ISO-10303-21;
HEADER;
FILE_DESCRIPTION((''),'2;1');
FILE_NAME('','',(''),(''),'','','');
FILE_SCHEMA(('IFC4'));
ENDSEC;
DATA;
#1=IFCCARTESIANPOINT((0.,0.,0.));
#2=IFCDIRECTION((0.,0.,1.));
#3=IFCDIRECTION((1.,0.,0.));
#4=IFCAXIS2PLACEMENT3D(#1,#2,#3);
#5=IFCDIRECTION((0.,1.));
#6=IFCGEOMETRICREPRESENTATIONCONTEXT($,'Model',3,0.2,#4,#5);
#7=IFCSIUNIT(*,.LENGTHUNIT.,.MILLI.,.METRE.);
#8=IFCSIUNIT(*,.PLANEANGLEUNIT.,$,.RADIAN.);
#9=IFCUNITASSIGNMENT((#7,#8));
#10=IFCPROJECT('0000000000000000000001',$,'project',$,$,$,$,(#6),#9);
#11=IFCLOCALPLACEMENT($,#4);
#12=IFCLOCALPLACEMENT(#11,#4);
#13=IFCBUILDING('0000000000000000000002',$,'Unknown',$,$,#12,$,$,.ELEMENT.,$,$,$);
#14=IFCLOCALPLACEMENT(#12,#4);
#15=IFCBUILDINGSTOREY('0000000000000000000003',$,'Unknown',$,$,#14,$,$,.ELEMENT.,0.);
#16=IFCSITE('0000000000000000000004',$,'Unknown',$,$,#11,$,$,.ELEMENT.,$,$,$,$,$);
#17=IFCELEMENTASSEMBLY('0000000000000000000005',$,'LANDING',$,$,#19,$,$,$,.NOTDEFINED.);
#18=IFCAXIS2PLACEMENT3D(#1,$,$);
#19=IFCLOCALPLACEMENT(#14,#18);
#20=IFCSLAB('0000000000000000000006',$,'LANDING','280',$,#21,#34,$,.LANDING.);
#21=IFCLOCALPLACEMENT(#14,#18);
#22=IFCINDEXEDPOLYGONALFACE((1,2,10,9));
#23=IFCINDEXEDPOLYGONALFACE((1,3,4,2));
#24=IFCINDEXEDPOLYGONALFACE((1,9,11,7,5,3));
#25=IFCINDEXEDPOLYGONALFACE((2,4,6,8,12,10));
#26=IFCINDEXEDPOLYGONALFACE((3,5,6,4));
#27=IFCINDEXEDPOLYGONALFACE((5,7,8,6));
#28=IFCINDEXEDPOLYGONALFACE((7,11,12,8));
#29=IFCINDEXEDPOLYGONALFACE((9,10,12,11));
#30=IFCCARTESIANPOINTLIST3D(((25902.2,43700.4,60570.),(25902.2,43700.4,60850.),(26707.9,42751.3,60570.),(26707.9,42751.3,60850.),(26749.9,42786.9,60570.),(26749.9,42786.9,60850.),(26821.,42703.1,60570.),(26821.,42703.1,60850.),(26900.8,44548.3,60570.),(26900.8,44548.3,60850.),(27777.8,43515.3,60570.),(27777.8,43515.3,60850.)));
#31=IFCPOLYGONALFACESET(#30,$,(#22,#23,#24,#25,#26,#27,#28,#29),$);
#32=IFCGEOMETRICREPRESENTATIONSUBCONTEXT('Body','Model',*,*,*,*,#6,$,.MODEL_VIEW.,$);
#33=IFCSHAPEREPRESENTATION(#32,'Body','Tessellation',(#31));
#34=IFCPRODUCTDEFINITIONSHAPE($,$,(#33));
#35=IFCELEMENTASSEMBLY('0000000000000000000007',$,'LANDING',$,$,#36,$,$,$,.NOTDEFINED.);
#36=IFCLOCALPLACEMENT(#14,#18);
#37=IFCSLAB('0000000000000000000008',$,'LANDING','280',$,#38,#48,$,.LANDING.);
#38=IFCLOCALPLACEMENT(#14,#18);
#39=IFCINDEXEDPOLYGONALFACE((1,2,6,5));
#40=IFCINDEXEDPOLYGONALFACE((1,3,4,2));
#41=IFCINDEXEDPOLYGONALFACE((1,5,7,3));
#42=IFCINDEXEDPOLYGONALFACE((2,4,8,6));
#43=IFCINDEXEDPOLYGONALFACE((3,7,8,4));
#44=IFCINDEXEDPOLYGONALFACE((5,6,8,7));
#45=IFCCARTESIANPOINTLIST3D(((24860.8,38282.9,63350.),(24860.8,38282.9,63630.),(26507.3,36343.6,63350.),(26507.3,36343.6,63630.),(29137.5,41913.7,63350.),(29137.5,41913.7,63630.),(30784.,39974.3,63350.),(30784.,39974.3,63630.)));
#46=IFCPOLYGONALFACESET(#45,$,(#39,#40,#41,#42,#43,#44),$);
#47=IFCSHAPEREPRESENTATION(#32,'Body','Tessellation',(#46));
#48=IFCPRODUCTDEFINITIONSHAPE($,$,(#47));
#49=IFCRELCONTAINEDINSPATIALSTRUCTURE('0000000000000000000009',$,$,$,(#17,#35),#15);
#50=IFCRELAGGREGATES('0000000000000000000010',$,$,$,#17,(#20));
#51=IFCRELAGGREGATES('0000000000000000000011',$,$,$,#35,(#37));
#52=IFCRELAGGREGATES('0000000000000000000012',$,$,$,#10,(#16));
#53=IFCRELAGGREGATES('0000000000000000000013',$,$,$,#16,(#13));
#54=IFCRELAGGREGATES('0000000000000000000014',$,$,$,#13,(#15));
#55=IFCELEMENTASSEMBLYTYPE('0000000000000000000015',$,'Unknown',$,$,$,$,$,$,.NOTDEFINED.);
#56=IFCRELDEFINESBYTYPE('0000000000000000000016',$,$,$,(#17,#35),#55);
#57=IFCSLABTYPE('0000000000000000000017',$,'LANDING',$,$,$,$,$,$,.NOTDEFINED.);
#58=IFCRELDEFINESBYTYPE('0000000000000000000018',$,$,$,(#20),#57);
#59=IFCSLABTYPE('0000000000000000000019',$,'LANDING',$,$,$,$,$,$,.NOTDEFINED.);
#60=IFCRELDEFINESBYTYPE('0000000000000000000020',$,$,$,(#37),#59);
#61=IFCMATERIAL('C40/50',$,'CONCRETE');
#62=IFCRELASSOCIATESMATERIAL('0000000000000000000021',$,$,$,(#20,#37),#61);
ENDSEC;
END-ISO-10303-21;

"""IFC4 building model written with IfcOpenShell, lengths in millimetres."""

from ifc_helpers import new_model, si_unit, direction, frame, origin_with_axes, place, context, subcontext, project, spatial, line, indexed_curve, outline, extrude, material, material_profile, profile_set, profile_usage, type_object, element, aggregate, save


model = new_model("IFC4")

# Units and contexts
model_context = context("Model", 3, precision=0.2, world=origin_with_axes(), true_north=direction((0.0, 1.0)))
body_context = subcontext(model_context, "Body", "Model", "MODEL_VIEW")
ifc_project = project(units=[si_unit("LENGTHUNIT", "METRE", prefix="MILLI"), si_unit("PLANEANGLEUNIT", "RADIAN")], contexts=[model_context])

# Site, building, storey
site_placement = place(None, origin_with_axes())
site = spatial("IfcSite", under=ifc_project, at=site_placement, Name="Unknown", CompositionType="ELEMENT")
building_placement = place(site_placement, origin_with_axes())
building = spatial("IfcBuilding", under=site, at=building_placement, Name="Unknown", CompositionType="ELEMENT")
storey_placement = place(building_placement, origin_with_axes())
storey = spatial("IfcBuildingStorey", under=building, at=storey_placement, Name="Unknown", CompositionType="ELEMENT", Elevation=0.0)

# Shared definitions
element_assembly_type = type_object("IfcElementAssemblyType", Name="Unknown", PredefinedType="NOTDEFINED")
ifc_material_1 = material(Name="C40/50", Category="CONCRETE")

# Element assemblies, slabs
assembly_1_placement = place(storey_placement, frame((27777.8, 43515.3, 60710.0), z_axis=(0.0, 0.0, 1.0), x_axis=(-0.64719, 0.762329, 0.0)))
assembly_1 = element("IfcElementAssembly", 1, at=assembly_1_placement, inside=storey, type_object=element_assembly_type, Name="LANDING", PredefinedType="NOTDEFINED")
ifc_material_profile_1 = material_profile(ifc_material_1, outline(indexed_curve([(0.0, 0.0), (1355.0, 0.0), (1355.0, 1310.0), (110.0, 1310.0), (110.0, 1255.0), (0.0, 1255.0)], segments=[line(1, 2, 3, 4, 5, 6, 1)])), Name="280")
ifc_profile_set_1 = profile_set([ifc_material_profile_1])
ifc_profile_usage_1 = profile_usage(ifc_profile_set_1, cardinal=8)
slab_type_1 = type_object("IfcSlabType", Name="LANDING")
slab_1_placement = place(assembly_1_placement, origin_with_axes())
slab_1 = element("IfcSlab", 2, at=slab_1_placement, type_object=slab_type_1, material=ifc_profile_usage_1, Name="LANDING", Description="280", PredefinedType="LANDING", context=body_context, shape_type="SolidModel", body=[
    extrude(outline(indexed_curve([(0.0, 0.0), (1355.0, 0.0), (1355.0, 1310.0), (110.0, 1310.0), (110.0, 1255.0), (0.0, 1255.0)], segments=[line(1, 2, 3, 4, 5, 6, 1)])), frame((0.0, 0.0, 140.0), z_axis=(0.0, 0.0, 1.0), x_axis=(1.0, 0.0, 0.0)), (0.0, 0.0, -1.0), 280.0),
])
aggregate(assembly_1, [slab_1])
assembly_2_placement = place(storey_placement, frame((26507.3, 36343.6, 63490.0), z_axis=(0.0, 0.0, 1.0), x_axis=(0.762329, 0.64719, 0.0)))
assembly_2 = element("IfcElementAssembly", 3, at=assembly_2_placement, inside=storey, type_object=element_assembly_type, Name="LANDING", PredefinedType="NOTDEFINED")
ifc_material_profile_2 = material_profile(ifc_material_1, outline(indexed_curve([(0.0, 0.0), (5610.0, 0.0), (5610.0, 2544.0), (0.0, 2544.0)], segments=[line(1, 2, 3, 4, 1)])), Name="280")
ifc_profile_set_2 = profile_set([ifc_material_profile_2])
ifc_profile_usage_2 = profile_usage(ifc_profile_set_2, cardinal=8)
slab_type_2 = type_object("IfcSlabType", Name="LANDING")
slab_2_placement = place(assembly_2_placement, origin_with_axes())
slab_2 = element("IfcSlab", 4, at=slab_2_placement, type_object=slab_type_2, material=ifc_profile_usage_2, Name="LANDING", Description="280", PredefinedType="LANDING", context=body_context, shape_type="SolidModel", body=[
    extrude(outline(indexed_curve([(0.0, 0.0), (5610.0, 0.0), (5610.0, 2544.0), (0.0, 2544.0)], segments=[line(1, 2, 3, 4, 1)])), frame((0.0, 0.0, 140.0), z_axis=(0.0, 0.0, 1.0), x_axis=(1.0, 0.0, 0.0)), (0.0, 0.0, -1.0), 280.0),
])
aggregate(assembly_2, [slab_2])

save(model, "model.ifc")
